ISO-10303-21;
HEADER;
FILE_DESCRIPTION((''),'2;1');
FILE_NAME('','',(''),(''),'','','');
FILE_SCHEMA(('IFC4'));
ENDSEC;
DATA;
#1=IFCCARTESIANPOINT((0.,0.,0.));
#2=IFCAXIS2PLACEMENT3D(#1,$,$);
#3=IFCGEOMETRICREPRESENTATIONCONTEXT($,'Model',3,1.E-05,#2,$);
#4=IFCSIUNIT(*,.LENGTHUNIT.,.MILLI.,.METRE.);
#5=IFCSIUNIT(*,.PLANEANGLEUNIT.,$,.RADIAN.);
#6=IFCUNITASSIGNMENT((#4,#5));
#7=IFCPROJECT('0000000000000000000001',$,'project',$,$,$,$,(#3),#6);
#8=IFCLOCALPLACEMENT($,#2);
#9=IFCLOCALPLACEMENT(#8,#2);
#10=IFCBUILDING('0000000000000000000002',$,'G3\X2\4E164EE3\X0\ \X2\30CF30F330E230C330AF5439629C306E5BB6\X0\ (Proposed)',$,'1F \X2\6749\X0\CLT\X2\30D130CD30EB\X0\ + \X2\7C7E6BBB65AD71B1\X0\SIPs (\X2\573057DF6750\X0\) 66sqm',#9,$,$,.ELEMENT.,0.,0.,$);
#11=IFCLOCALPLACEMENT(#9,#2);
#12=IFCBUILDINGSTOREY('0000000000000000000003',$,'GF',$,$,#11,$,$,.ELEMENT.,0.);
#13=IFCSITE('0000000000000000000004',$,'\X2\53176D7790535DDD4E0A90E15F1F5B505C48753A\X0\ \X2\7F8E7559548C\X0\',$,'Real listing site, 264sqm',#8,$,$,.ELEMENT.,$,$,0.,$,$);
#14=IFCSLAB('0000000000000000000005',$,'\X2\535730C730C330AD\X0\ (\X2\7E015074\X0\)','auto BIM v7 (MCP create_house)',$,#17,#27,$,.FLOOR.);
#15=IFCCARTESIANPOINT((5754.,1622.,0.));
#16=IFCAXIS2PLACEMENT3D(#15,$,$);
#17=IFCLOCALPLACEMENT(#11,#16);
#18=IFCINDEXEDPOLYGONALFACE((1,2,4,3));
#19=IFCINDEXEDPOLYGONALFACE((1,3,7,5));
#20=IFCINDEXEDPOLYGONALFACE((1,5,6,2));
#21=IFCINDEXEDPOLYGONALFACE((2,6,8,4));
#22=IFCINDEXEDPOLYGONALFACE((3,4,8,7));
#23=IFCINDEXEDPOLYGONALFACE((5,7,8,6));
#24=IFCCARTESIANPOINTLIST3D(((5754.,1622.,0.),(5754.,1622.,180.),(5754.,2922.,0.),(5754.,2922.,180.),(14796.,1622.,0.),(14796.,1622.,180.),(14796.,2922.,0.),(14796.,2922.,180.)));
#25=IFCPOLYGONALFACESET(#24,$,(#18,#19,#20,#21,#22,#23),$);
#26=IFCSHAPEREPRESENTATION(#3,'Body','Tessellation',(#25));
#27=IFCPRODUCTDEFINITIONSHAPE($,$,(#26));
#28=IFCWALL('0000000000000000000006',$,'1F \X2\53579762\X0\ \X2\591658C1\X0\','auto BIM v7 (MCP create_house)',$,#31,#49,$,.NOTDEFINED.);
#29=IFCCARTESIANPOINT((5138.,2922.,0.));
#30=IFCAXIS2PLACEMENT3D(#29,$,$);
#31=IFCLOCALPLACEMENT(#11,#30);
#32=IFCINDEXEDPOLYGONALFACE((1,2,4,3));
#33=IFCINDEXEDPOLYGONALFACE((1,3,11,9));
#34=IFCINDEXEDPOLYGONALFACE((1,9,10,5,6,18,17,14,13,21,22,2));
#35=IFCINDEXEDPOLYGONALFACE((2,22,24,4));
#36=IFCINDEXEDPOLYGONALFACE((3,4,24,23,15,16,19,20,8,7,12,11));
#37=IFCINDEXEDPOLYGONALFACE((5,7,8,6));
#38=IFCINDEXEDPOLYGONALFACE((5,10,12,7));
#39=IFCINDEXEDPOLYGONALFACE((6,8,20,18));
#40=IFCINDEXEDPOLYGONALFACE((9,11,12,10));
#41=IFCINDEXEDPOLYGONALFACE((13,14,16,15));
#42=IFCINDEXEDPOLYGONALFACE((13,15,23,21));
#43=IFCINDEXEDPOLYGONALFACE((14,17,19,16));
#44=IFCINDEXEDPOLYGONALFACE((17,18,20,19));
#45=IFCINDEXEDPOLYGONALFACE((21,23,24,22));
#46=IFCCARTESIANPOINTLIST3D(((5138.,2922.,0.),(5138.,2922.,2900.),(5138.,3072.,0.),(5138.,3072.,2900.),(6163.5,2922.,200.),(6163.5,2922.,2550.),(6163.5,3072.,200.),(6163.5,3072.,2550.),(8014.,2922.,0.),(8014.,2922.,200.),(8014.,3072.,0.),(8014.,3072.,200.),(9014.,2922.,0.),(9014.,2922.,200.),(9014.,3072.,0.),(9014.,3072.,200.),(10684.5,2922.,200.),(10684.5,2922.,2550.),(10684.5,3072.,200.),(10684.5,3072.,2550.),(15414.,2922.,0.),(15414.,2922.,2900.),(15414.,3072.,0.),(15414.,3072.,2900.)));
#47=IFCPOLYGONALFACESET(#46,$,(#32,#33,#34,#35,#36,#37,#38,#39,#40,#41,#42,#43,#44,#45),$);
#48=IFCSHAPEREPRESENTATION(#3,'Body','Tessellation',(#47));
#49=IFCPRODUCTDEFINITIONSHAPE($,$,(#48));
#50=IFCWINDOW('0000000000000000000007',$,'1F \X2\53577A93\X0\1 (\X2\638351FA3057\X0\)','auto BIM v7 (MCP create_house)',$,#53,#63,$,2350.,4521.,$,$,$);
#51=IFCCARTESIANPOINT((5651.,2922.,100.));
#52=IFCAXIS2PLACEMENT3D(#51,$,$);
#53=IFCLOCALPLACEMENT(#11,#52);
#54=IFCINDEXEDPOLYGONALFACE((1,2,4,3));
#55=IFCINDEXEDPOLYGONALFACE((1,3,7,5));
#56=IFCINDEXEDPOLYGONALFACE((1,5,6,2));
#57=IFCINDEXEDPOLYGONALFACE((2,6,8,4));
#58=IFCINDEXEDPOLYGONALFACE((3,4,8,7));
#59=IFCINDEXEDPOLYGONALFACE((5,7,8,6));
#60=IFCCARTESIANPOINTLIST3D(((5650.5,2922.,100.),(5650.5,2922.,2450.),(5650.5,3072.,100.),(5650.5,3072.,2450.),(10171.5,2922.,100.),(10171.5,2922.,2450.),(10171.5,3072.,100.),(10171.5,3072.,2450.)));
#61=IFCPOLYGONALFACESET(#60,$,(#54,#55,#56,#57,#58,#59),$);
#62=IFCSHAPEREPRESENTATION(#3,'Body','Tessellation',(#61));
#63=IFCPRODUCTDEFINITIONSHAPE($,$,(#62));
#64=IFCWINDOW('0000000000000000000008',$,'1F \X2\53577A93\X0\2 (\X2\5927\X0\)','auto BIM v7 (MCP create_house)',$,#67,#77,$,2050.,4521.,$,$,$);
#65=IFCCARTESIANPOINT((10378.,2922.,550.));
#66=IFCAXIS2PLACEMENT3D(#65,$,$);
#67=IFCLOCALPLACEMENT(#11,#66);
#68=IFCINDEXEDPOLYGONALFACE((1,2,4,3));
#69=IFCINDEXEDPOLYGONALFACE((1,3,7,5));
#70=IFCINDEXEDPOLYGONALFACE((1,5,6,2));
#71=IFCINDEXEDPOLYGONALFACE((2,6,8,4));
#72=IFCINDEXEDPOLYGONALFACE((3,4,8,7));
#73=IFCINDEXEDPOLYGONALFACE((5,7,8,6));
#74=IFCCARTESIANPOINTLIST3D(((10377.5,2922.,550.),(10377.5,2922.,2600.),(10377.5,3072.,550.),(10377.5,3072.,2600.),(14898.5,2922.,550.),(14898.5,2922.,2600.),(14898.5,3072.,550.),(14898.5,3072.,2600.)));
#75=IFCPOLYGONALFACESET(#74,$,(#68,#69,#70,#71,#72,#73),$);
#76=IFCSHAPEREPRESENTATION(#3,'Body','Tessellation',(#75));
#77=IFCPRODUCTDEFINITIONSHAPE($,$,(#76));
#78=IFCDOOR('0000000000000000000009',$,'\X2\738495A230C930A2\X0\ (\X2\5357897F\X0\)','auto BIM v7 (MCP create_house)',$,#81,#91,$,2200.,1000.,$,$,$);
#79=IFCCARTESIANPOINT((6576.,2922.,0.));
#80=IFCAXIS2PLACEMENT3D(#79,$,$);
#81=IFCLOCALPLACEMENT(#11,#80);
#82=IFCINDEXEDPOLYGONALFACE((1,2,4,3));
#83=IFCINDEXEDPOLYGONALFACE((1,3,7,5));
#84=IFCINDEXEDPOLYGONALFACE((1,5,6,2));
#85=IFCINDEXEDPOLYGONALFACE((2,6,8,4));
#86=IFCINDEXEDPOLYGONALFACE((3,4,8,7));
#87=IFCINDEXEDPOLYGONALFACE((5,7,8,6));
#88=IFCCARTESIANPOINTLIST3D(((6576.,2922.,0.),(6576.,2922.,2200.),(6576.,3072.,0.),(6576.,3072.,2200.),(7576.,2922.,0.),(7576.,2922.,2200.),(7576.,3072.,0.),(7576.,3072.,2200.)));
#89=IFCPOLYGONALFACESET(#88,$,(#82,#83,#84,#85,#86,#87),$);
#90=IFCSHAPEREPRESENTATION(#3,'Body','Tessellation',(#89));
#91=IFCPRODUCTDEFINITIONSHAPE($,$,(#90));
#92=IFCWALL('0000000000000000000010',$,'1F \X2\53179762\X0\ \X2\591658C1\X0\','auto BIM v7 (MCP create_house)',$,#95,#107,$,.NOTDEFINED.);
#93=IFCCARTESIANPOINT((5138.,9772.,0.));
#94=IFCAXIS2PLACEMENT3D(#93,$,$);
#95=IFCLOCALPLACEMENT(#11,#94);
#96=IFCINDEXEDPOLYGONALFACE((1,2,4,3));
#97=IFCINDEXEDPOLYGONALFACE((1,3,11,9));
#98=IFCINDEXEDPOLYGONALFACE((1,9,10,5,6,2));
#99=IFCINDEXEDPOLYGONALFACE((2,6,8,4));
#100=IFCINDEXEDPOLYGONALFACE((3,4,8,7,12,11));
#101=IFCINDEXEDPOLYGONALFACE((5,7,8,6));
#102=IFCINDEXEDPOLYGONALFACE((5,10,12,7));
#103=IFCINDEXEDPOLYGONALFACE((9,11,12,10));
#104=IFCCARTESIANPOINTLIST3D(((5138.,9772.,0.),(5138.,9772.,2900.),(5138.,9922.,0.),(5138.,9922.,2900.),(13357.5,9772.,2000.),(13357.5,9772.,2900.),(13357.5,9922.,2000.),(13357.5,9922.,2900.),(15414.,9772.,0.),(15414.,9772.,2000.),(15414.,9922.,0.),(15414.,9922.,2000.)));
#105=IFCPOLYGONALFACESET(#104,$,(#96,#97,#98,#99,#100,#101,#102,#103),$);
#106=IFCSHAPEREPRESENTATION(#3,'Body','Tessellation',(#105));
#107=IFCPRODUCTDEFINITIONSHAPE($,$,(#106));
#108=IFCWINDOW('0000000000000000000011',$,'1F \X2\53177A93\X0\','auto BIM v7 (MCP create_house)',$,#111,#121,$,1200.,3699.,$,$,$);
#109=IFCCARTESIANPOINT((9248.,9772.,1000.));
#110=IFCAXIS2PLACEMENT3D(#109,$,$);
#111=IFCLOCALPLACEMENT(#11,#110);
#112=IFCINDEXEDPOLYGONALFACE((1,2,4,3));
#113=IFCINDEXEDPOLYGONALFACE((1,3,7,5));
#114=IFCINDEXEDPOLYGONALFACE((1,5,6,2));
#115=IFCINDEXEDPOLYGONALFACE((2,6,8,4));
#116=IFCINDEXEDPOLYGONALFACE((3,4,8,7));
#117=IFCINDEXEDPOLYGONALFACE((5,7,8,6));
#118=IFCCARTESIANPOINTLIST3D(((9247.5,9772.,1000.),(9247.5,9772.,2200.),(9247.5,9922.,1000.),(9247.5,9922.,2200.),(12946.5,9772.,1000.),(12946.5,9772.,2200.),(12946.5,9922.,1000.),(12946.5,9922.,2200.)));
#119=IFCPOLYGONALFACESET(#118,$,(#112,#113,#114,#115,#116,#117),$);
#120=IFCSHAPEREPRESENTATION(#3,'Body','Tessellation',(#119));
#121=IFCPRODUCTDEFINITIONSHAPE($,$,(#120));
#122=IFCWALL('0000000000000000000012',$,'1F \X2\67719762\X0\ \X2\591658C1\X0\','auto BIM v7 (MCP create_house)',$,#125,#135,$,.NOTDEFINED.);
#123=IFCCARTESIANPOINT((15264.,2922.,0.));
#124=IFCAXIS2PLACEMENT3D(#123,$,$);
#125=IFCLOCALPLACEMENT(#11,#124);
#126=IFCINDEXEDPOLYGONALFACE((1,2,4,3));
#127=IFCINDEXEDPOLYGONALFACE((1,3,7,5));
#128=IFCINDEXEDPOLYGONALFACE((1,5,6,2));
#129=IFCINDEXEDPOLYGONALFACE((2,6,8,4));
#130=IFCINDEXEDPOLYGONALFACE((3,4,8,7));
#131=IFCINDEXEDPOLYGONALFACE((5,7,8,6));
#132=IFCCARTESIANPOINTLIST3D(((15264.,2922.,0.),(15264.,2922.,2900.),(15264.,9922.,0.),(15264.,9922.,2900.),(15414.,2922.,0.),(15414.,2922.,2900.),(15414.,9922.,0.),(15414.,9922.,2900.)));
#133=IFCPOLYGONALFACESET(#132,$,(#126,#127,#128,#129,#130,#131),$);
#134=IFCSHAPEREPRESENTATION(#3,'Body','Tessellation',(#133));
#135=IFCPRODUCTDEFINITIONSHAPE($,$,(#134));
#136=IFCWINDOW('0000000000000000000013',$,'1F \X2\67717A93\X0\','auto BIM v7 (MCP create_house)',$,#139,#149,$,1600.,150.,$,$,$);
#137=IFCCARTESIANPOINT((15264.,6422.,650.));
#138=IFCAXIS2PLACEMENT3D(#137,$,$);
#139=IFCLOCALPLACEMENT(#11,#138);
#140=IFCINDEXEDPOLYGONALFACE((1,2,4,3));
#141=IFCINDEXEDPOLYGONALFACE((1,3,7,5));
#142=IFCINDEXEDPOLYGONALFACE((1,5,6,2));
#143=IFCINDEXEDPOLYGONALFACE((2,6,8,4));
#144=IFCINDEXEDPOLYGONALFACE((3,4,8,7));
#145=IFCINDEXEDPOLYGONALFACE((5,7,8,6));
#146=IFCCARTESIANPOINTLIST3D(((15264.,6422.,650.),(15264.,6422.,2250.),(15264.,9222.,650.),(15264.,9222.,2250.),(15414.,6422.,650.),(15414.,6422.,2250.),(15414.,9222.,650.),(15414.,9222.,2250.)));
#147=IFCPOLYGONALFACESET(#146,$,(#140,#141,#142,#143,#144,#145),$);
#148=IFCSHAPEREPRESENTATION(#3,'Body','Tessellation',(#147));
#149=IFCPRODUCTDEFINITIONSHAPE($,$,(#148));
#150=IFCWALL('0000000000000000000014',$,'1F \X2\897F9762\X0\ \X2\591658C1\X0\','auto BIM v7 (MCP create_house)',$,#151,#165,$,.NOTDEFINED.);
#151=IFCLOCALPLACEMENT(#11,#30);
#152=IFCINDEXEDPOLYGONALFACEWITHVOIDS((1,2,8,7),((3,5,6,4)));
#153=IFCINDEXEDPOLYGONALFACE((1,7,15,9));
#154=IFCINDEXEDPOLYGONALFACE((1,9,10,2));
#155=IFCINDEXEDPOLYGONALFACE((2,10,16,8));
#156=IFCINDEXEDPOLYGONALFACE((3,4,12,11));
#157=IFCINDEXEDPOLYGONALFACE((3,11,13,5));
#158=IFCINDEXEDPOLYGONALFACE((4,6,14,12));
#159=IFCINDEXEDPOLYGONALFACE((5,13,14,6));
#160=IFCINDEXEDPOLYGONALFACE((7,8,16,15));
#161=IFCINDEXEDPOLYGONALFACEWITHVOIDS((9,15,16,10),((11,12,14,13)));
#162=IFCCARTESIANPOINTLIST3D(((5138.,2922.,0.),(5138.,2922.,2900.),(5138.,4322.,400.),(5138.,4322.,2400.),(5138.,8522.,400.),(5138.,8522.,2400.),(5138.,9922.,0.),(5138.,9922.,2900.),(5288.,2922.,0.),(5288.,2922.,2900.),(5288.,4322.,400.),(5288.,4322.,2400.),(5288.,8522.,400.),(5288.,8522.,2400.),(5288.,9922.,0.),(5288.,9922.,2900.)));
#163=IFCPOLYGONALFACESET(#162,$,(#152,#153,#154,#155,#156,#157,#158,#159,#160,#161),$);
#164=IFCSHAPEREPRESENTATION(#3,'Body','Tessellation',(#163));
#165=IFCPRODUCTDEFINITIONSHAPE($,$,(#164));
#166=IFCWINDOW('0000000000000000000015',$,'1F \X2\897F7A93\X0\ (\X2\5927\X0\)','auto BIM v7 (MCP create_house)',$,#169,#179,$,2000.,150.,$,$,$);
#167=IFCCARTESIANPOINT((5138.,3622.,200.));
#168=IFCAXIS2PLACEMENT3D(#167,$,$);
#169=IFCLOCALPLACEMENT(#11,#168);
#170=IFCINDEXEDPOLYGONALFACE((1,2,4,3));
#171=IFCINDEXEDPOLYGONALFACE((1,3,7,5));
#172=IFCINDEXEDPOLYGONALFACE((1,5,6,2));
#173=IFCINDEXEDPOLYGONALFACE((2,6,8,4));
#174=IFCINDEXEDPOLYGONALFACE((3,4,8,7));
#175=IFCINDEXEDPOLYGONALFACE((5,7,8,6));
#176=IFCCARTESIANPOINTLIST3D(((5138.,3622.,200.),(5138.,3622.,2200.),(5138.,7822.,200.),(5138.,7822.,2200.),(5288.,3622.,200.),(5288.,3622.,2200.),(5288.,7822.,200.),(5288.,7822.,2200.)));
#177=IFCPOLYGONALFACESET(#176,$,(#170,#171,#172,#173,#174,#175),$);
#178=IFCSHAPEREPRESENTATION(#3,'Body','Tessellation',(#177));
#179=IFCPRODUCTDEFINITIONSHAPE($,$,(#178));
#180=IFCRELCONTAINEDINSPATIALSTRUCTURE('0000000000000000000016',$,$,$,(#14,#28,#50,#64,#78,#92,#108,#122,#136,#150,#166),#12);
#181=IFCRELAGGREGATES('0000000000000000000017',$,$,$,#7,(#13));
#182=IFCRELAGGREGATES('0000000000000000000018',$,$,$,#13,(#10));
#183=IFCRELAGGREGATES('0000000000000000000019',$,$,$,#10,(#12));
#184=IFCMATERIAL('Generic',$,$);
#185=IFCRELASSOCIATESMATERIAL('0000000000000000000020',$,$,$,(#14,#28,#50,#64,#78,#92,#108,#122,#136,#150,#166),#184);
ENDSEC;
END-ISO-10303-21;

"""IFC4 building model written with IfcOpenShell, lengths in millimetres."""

from ifc_helpers import new_model, si_unit, frame, frame_2d, origin, place, context, project, spatial, rectangle, extrude, material, element, fill, save


model = new_model("IFC4")

# Units and contexts
model_context = context("Model", 3, precision=1e-05, world=origin())
ifc_project = project(units=[si_unit("LENGTHUNIT", "METRE", prefix="MILLI"), si_unit("PLANEANGLEUNIT", "RADIAN")], contexts=[model_context])

# Site, building, storey
site_placement = place(None, origin())
site = spatial("IfcSite", under=ifc_project, at=site_placement, Name="北海道川上郡弟子屈町 美留和", ObjectType="Real listing site, 264sqm", CompositionType="ELEMENT", RefElevation=0.0)
building_placement = place(site_placement, origin())
building = spatial("IfcBuilding", under=site, at=building_placement, Name="G3世代 ハンモック吹抜の家 (Proposed)", ObjectType="1F 杉CLTパネル + 籾殻断熱SIPs (地域材) 66sqm", CompositionType="ELEMENT", ElevationOfRefHeight=0.0, ElevationOfTerrain=0.0)
storey_placement = place(building_placement, origin())
storey = spatial("IfcBuildingStorey", under=building, at=storey_placement, Name="GF", CompositionType="ELEMENT", Elevation=0.0)

# Slab
ifc_material = material(Name="Generic")
slab_1_placement = place(storey_placement, frame((5754.0, 1622.0, 0.0)))
element("IfcSlab", 1, at=slab_1_placement, inside=storey, material=ifc_material, Name="南デッキ (縁側)", Description="auto BIM v7 (MCP create_house)", PredefinedType="FLOOR", context=model_context, shape_type="SweptSolid", body=[
    extrude(rectangle(XDim=9042.0, YDim=1300.0, at=frame_2d((4521.0, 650.0))), frame((5754.0, 1622.0, 0.0)), (0.0, 0.0, 1.0), 180.0),
])

# Wall, openings, windows, door
wall_1_placement = place(storey_placement, frame((5138.0, 2922.0, 0.0)))
wall_1 = element("IfcWall", 2, at=wall_1_placement, inside=storey, material=ifc_material, Name="1F 南面 外壁", Description="auto BIM v7 (MCP create_house)", PredefinedType="NOTDEFINED", context=model_context, shape_type="SweptSolid", body=[
    extrude(rectangle(XDim=10276.0, YDim=150.0, at=frame_2d((5138.0, 75.0))), frame((5138.0, 2922.0, 0.0)), (0.0, 0.0, 1.0), 2900.0),
])
opening_1_placement = place(storey_placement, frame((5651.0, 2922.0, 100.0)))
opening_1 = element("IfcOpeningElement", 3, at=opening_1_placement, cuts=wall_1, PredefinedType="NOTDEFINED", context=model_context, shape_type="SweptSolid", body=[
    extrude(rectangle(XDim=4521.0, YDim=150.0, at=frame_2d((2260.0, 75.0))), frame((5651.0, 2922.0, 100.0)), (0.0, 0.0, 1.0), 2350.0),
])
opening_2_placement = place(storey_placement, frame((10378.0, 2922.0, 550.0)))
opening_2 = element("IfcOpeningElement", 4, at=opening_2_placement, cuts=wall_1, PredefinedType="NOTDEFINED", context=model_context, shape_type="SweptSolid", body=[
    extrude(rectangle(XDim=4521.0, YDim=150.0, at=frame_2d((2260.0, 75.0))), frame((10378.0, 2922.0, 550.0)), (0.0, 0.0, 1.0), 2050.0),
])
opening_3_placement = place(storey_placement, frame((6576.0, 2922.0, 0.0)))
opening_3 = element("IfcOpeningElement", 5, at=opening_3_placement, cuts=wall_1, PredefinedType="NOTDEFINED", context=model_context, shape_type="SweptSolid", body=[
    extrude(rectangle(XDim=1000.0, YDim=150.0, at=frame_2d((500.0, 75.0))), frame((6576.0, 2922.0, 0.0)), (0.0, 0.0, 1.0), 2200.0),
])
window_1_placement = place(storey_placement, frame((5651.0, 2922.0, 100.0)))
window_1 = element("IfcWindow", 6, at=window_1_placement, inside=storey, material=ifc_material, Name="1F 南窓1 (掃出し)", Description="auto BIM v7 (MCP create_house)", OverallHeight=2350.0, OverallWidth=4521.0, context=model_context, shape_type="SweptSolid", body=[
    extrude(rectangle(XDim=4521.0, YDim=150.0, at=frame_2d((2260.0, 75.0))), frame((5651.0, 2922.0, 100.0)), (0.0, 0.0, 1.0), 2350.0),
])
fill(opening_1, window_1)
window_2_placement = place(storey_placement, frame((10378.0, 2922.0, 550.0)))
window_2 = element("IfcWindow", 7, at=window_2_placement, inside=storey, material=ifc_material, Name="1F 南窓2 (大)", Description="auto BIM v7 (MCP create_house)", OverallHeight=2050.0, OverallWidth=4521.0, context=model_context, shape_type="SweptSolid", body=[
    extrude(rectangle(XDim=4521.0, YDim=150.0, at=frame_2d((2260.0, 75.0))), frame((10378.0, 2922.0, 550.0)), (0.0, 0.0, 1.0), 2050.0),
])
fill(opening_2, window_2)
door_placement = place(storey_placement, frame((6576.0, 2922.0, 0.0)))
door = element("IfcDoor", 8, at=door_placement, inside=storey, material=ifc_material, Name="玄関ドア (南西)", Description="auto BIM v7 (MCP create_house)", OverallHeight=2200.0, OverallWidth=1000.0, context=model_context, shape_type="SweptSolid", body=[
    extrude(rectangle(XDim=1000.0, YDim=150.0, at=frame_2d((500.0, 75.0))), frame((6576.0, 2922.0, 0.0)), (0.0, 0.0, 1.0), 2200.0),
])
fill(opening_3, door)

# Walls, openings, windows
wall_2_placement = place(storey_placement, frame((5138.0, 9772.0, 0.0)))
wall_2 = element("IfcWall", 9, at=wall_2_placement, inside=storey, material=ifc_material, Name="1F 北面 外壁", Description="auto BIM v7 (MCP create_house)", PredefinedType="NOTDEFINED", context=model_context, shape_type="SweptSolid", body=[
    extrude(rectangle(XDim=10276.0, YDim=150.0, at=frame_2d((5138.0, 75.0))), frame((5138.0, 9772.0, 0.0)), (0.0, 0.0, 1.0), 2900.0),
])
opening_4_placement = place(storey_placement, frame((9248.0, 9772.0, 1000.0)))
opening_4 = element("IfcOpeningElement", 10, at=opening_4_placement, cuts=wall_2, PredefinedType="NOTDEFINED", context=model_context, shape_type="SweptSolid", body=[
    extrude(rectangle(XDim=3699.0, YDim=150.0, at=frame_2d((1849.0, 75.0))), frame((9248.0, 9772.0, 1000.0)), (0.0, 0.0, 1.0), 1200.0),
])
window_3_placement = place(storey_placement, frame((9248.0, 9772.0, 1000.0)))
window_3 = element("IfcWindow", 11, at=window_3_placement, inside=storey, material=ifc_material, Name="1F 北窓", Description="auto BIM v7 (MCP create_house)", OverallHeight=1200.0, OverallWidth=3699.0, context=model_context, shape_type="SweptSolid", body=[
    extrude(rectangle(XDim=3699.0, YDim=150.0, at=frame_2d((1849.0, 75.0))), frame((9248.0, 9772.0, 1000.0)), (0.0, 0.0, 1.0), 1200.0),
])
fill(opening_4, window_3)
wall_3_placement = place(storey_placement, frame((15264.0, 2922.0, 0.0)))
wall_3 = element("IfcWall", 12, at=wall_3_placement, inside=storey, material=ifc_material, Name="1F 東面 外壁", Description="auto BIM v7 (MCP create_house)", PredefinedType="NOTDEFINED", context=model_context, shape_type="SweptSolid", body=[
    extrude(rectangle(XDim=150.0, YDim=7000.0, at=frame_2d((75.0, 3500.0))), frame((15264.0, 2922.0, 0.0)), (0.0, 0.0, 1.0), 2900.0),
])
opening_5_placement = place(storey_placement, frame((15264.0, 6422.0, 650.0)))
opening_5 = element("IfcOpeningElement", 13, at=opening_5_placement, cuts=wall_3, PredefinedType="NOTDEFINED", context=model_context, shape_type="SweptSolid", body=[
    extrude(rectangle(XDim=150.0, YDim=2800.0, at=frame_2d((75.0, 1400.0))), frame((15264.0, 6422.0, 650.0)), (0.0, 0.0, 1.0), 1600.0),
])
window_4_placement = place(storey_placement, frame((15264.0, 6422.0, 650.0)))
window_4 = element("IfcWindow", 14, at=window_4_placement, inside=storey, material=ifc_material, Name="1F 東窓", Description="auto BIM v7 (MCP create_house)", OverallHeight=1600.0, OverallWidth=150.0, context=model_context, shape_type="SweptSolid", body=[
    extrude(rectangle(XDim=150.0, YDim=2800.0, at=frame_2d((75.0, 1400.0))), frame((15264.0, 6422.0, 650.0)), (0.0, 0.0, 1.0), 1600.0),
])
fill(opening_5, window_4)
wall_4_placement = place(storey_placement, frame((5138.0, 2922.0, 0.0)))
wall_4 = element("IfcWall", 15, at=wall_4_placement, inside=storey, material=ifc_material, Name="1F 西面 外壁", Description="auto BIM v7 (MCP create_house)", PredefinedType="NOTDEFINED", context=model_context, shape_type="SweptSolid", body=[
    extrude(rectangle(XDim=150.0, YDim=7000.0, at=frame_2d((75.0, 3500.0))), frame((5138.0, 2922.0, 0.0)), (0.0, 0.0, 1.0), 2900.0),
])
opening_6_placement = place(storey_placement, frame((5138.0, 3622.0, 200.0)))
opening_6 = element("IfcOpeningElement", 16, at=opening_6_placement, cuts=wall_4, PredefinedType="NOTDEFINED", context=model_context, shape_type="SweptSolid", body=[
    extrude(rectangle(XDim=150.0, YDim=4200.0, at=frame_2d((75.0, 2100.0))), frame((5138.0, 3622.0, 200.0)), (0.0, 0.0, 1.0), 2000.0),
])
window_5_placement = place(storey_placement, frame((5138.0, 3622.0, 200.0)))
window_5 = element("IfcWindow", 17, at=window_5_placement, inside=storey, material=ifc_material, Name="1F 西窓 (大)", Description="auto BIM v7 (MCP create_house)", OverallHeight=2000.0, OverallWidth=150.0, context=model_context, shape_type="SweptSolid", body=[
    extrude(rectangle(XDim=150.0, YDim=4200.0, at=frame_2d((75.0, 2100.0))), frame((5138.0, 3622.0, 200.0)), (0.0, 0.0, 1.0), 2000.0),
])
fill(opening_6, window_5)

save(model, "model.ifc")
